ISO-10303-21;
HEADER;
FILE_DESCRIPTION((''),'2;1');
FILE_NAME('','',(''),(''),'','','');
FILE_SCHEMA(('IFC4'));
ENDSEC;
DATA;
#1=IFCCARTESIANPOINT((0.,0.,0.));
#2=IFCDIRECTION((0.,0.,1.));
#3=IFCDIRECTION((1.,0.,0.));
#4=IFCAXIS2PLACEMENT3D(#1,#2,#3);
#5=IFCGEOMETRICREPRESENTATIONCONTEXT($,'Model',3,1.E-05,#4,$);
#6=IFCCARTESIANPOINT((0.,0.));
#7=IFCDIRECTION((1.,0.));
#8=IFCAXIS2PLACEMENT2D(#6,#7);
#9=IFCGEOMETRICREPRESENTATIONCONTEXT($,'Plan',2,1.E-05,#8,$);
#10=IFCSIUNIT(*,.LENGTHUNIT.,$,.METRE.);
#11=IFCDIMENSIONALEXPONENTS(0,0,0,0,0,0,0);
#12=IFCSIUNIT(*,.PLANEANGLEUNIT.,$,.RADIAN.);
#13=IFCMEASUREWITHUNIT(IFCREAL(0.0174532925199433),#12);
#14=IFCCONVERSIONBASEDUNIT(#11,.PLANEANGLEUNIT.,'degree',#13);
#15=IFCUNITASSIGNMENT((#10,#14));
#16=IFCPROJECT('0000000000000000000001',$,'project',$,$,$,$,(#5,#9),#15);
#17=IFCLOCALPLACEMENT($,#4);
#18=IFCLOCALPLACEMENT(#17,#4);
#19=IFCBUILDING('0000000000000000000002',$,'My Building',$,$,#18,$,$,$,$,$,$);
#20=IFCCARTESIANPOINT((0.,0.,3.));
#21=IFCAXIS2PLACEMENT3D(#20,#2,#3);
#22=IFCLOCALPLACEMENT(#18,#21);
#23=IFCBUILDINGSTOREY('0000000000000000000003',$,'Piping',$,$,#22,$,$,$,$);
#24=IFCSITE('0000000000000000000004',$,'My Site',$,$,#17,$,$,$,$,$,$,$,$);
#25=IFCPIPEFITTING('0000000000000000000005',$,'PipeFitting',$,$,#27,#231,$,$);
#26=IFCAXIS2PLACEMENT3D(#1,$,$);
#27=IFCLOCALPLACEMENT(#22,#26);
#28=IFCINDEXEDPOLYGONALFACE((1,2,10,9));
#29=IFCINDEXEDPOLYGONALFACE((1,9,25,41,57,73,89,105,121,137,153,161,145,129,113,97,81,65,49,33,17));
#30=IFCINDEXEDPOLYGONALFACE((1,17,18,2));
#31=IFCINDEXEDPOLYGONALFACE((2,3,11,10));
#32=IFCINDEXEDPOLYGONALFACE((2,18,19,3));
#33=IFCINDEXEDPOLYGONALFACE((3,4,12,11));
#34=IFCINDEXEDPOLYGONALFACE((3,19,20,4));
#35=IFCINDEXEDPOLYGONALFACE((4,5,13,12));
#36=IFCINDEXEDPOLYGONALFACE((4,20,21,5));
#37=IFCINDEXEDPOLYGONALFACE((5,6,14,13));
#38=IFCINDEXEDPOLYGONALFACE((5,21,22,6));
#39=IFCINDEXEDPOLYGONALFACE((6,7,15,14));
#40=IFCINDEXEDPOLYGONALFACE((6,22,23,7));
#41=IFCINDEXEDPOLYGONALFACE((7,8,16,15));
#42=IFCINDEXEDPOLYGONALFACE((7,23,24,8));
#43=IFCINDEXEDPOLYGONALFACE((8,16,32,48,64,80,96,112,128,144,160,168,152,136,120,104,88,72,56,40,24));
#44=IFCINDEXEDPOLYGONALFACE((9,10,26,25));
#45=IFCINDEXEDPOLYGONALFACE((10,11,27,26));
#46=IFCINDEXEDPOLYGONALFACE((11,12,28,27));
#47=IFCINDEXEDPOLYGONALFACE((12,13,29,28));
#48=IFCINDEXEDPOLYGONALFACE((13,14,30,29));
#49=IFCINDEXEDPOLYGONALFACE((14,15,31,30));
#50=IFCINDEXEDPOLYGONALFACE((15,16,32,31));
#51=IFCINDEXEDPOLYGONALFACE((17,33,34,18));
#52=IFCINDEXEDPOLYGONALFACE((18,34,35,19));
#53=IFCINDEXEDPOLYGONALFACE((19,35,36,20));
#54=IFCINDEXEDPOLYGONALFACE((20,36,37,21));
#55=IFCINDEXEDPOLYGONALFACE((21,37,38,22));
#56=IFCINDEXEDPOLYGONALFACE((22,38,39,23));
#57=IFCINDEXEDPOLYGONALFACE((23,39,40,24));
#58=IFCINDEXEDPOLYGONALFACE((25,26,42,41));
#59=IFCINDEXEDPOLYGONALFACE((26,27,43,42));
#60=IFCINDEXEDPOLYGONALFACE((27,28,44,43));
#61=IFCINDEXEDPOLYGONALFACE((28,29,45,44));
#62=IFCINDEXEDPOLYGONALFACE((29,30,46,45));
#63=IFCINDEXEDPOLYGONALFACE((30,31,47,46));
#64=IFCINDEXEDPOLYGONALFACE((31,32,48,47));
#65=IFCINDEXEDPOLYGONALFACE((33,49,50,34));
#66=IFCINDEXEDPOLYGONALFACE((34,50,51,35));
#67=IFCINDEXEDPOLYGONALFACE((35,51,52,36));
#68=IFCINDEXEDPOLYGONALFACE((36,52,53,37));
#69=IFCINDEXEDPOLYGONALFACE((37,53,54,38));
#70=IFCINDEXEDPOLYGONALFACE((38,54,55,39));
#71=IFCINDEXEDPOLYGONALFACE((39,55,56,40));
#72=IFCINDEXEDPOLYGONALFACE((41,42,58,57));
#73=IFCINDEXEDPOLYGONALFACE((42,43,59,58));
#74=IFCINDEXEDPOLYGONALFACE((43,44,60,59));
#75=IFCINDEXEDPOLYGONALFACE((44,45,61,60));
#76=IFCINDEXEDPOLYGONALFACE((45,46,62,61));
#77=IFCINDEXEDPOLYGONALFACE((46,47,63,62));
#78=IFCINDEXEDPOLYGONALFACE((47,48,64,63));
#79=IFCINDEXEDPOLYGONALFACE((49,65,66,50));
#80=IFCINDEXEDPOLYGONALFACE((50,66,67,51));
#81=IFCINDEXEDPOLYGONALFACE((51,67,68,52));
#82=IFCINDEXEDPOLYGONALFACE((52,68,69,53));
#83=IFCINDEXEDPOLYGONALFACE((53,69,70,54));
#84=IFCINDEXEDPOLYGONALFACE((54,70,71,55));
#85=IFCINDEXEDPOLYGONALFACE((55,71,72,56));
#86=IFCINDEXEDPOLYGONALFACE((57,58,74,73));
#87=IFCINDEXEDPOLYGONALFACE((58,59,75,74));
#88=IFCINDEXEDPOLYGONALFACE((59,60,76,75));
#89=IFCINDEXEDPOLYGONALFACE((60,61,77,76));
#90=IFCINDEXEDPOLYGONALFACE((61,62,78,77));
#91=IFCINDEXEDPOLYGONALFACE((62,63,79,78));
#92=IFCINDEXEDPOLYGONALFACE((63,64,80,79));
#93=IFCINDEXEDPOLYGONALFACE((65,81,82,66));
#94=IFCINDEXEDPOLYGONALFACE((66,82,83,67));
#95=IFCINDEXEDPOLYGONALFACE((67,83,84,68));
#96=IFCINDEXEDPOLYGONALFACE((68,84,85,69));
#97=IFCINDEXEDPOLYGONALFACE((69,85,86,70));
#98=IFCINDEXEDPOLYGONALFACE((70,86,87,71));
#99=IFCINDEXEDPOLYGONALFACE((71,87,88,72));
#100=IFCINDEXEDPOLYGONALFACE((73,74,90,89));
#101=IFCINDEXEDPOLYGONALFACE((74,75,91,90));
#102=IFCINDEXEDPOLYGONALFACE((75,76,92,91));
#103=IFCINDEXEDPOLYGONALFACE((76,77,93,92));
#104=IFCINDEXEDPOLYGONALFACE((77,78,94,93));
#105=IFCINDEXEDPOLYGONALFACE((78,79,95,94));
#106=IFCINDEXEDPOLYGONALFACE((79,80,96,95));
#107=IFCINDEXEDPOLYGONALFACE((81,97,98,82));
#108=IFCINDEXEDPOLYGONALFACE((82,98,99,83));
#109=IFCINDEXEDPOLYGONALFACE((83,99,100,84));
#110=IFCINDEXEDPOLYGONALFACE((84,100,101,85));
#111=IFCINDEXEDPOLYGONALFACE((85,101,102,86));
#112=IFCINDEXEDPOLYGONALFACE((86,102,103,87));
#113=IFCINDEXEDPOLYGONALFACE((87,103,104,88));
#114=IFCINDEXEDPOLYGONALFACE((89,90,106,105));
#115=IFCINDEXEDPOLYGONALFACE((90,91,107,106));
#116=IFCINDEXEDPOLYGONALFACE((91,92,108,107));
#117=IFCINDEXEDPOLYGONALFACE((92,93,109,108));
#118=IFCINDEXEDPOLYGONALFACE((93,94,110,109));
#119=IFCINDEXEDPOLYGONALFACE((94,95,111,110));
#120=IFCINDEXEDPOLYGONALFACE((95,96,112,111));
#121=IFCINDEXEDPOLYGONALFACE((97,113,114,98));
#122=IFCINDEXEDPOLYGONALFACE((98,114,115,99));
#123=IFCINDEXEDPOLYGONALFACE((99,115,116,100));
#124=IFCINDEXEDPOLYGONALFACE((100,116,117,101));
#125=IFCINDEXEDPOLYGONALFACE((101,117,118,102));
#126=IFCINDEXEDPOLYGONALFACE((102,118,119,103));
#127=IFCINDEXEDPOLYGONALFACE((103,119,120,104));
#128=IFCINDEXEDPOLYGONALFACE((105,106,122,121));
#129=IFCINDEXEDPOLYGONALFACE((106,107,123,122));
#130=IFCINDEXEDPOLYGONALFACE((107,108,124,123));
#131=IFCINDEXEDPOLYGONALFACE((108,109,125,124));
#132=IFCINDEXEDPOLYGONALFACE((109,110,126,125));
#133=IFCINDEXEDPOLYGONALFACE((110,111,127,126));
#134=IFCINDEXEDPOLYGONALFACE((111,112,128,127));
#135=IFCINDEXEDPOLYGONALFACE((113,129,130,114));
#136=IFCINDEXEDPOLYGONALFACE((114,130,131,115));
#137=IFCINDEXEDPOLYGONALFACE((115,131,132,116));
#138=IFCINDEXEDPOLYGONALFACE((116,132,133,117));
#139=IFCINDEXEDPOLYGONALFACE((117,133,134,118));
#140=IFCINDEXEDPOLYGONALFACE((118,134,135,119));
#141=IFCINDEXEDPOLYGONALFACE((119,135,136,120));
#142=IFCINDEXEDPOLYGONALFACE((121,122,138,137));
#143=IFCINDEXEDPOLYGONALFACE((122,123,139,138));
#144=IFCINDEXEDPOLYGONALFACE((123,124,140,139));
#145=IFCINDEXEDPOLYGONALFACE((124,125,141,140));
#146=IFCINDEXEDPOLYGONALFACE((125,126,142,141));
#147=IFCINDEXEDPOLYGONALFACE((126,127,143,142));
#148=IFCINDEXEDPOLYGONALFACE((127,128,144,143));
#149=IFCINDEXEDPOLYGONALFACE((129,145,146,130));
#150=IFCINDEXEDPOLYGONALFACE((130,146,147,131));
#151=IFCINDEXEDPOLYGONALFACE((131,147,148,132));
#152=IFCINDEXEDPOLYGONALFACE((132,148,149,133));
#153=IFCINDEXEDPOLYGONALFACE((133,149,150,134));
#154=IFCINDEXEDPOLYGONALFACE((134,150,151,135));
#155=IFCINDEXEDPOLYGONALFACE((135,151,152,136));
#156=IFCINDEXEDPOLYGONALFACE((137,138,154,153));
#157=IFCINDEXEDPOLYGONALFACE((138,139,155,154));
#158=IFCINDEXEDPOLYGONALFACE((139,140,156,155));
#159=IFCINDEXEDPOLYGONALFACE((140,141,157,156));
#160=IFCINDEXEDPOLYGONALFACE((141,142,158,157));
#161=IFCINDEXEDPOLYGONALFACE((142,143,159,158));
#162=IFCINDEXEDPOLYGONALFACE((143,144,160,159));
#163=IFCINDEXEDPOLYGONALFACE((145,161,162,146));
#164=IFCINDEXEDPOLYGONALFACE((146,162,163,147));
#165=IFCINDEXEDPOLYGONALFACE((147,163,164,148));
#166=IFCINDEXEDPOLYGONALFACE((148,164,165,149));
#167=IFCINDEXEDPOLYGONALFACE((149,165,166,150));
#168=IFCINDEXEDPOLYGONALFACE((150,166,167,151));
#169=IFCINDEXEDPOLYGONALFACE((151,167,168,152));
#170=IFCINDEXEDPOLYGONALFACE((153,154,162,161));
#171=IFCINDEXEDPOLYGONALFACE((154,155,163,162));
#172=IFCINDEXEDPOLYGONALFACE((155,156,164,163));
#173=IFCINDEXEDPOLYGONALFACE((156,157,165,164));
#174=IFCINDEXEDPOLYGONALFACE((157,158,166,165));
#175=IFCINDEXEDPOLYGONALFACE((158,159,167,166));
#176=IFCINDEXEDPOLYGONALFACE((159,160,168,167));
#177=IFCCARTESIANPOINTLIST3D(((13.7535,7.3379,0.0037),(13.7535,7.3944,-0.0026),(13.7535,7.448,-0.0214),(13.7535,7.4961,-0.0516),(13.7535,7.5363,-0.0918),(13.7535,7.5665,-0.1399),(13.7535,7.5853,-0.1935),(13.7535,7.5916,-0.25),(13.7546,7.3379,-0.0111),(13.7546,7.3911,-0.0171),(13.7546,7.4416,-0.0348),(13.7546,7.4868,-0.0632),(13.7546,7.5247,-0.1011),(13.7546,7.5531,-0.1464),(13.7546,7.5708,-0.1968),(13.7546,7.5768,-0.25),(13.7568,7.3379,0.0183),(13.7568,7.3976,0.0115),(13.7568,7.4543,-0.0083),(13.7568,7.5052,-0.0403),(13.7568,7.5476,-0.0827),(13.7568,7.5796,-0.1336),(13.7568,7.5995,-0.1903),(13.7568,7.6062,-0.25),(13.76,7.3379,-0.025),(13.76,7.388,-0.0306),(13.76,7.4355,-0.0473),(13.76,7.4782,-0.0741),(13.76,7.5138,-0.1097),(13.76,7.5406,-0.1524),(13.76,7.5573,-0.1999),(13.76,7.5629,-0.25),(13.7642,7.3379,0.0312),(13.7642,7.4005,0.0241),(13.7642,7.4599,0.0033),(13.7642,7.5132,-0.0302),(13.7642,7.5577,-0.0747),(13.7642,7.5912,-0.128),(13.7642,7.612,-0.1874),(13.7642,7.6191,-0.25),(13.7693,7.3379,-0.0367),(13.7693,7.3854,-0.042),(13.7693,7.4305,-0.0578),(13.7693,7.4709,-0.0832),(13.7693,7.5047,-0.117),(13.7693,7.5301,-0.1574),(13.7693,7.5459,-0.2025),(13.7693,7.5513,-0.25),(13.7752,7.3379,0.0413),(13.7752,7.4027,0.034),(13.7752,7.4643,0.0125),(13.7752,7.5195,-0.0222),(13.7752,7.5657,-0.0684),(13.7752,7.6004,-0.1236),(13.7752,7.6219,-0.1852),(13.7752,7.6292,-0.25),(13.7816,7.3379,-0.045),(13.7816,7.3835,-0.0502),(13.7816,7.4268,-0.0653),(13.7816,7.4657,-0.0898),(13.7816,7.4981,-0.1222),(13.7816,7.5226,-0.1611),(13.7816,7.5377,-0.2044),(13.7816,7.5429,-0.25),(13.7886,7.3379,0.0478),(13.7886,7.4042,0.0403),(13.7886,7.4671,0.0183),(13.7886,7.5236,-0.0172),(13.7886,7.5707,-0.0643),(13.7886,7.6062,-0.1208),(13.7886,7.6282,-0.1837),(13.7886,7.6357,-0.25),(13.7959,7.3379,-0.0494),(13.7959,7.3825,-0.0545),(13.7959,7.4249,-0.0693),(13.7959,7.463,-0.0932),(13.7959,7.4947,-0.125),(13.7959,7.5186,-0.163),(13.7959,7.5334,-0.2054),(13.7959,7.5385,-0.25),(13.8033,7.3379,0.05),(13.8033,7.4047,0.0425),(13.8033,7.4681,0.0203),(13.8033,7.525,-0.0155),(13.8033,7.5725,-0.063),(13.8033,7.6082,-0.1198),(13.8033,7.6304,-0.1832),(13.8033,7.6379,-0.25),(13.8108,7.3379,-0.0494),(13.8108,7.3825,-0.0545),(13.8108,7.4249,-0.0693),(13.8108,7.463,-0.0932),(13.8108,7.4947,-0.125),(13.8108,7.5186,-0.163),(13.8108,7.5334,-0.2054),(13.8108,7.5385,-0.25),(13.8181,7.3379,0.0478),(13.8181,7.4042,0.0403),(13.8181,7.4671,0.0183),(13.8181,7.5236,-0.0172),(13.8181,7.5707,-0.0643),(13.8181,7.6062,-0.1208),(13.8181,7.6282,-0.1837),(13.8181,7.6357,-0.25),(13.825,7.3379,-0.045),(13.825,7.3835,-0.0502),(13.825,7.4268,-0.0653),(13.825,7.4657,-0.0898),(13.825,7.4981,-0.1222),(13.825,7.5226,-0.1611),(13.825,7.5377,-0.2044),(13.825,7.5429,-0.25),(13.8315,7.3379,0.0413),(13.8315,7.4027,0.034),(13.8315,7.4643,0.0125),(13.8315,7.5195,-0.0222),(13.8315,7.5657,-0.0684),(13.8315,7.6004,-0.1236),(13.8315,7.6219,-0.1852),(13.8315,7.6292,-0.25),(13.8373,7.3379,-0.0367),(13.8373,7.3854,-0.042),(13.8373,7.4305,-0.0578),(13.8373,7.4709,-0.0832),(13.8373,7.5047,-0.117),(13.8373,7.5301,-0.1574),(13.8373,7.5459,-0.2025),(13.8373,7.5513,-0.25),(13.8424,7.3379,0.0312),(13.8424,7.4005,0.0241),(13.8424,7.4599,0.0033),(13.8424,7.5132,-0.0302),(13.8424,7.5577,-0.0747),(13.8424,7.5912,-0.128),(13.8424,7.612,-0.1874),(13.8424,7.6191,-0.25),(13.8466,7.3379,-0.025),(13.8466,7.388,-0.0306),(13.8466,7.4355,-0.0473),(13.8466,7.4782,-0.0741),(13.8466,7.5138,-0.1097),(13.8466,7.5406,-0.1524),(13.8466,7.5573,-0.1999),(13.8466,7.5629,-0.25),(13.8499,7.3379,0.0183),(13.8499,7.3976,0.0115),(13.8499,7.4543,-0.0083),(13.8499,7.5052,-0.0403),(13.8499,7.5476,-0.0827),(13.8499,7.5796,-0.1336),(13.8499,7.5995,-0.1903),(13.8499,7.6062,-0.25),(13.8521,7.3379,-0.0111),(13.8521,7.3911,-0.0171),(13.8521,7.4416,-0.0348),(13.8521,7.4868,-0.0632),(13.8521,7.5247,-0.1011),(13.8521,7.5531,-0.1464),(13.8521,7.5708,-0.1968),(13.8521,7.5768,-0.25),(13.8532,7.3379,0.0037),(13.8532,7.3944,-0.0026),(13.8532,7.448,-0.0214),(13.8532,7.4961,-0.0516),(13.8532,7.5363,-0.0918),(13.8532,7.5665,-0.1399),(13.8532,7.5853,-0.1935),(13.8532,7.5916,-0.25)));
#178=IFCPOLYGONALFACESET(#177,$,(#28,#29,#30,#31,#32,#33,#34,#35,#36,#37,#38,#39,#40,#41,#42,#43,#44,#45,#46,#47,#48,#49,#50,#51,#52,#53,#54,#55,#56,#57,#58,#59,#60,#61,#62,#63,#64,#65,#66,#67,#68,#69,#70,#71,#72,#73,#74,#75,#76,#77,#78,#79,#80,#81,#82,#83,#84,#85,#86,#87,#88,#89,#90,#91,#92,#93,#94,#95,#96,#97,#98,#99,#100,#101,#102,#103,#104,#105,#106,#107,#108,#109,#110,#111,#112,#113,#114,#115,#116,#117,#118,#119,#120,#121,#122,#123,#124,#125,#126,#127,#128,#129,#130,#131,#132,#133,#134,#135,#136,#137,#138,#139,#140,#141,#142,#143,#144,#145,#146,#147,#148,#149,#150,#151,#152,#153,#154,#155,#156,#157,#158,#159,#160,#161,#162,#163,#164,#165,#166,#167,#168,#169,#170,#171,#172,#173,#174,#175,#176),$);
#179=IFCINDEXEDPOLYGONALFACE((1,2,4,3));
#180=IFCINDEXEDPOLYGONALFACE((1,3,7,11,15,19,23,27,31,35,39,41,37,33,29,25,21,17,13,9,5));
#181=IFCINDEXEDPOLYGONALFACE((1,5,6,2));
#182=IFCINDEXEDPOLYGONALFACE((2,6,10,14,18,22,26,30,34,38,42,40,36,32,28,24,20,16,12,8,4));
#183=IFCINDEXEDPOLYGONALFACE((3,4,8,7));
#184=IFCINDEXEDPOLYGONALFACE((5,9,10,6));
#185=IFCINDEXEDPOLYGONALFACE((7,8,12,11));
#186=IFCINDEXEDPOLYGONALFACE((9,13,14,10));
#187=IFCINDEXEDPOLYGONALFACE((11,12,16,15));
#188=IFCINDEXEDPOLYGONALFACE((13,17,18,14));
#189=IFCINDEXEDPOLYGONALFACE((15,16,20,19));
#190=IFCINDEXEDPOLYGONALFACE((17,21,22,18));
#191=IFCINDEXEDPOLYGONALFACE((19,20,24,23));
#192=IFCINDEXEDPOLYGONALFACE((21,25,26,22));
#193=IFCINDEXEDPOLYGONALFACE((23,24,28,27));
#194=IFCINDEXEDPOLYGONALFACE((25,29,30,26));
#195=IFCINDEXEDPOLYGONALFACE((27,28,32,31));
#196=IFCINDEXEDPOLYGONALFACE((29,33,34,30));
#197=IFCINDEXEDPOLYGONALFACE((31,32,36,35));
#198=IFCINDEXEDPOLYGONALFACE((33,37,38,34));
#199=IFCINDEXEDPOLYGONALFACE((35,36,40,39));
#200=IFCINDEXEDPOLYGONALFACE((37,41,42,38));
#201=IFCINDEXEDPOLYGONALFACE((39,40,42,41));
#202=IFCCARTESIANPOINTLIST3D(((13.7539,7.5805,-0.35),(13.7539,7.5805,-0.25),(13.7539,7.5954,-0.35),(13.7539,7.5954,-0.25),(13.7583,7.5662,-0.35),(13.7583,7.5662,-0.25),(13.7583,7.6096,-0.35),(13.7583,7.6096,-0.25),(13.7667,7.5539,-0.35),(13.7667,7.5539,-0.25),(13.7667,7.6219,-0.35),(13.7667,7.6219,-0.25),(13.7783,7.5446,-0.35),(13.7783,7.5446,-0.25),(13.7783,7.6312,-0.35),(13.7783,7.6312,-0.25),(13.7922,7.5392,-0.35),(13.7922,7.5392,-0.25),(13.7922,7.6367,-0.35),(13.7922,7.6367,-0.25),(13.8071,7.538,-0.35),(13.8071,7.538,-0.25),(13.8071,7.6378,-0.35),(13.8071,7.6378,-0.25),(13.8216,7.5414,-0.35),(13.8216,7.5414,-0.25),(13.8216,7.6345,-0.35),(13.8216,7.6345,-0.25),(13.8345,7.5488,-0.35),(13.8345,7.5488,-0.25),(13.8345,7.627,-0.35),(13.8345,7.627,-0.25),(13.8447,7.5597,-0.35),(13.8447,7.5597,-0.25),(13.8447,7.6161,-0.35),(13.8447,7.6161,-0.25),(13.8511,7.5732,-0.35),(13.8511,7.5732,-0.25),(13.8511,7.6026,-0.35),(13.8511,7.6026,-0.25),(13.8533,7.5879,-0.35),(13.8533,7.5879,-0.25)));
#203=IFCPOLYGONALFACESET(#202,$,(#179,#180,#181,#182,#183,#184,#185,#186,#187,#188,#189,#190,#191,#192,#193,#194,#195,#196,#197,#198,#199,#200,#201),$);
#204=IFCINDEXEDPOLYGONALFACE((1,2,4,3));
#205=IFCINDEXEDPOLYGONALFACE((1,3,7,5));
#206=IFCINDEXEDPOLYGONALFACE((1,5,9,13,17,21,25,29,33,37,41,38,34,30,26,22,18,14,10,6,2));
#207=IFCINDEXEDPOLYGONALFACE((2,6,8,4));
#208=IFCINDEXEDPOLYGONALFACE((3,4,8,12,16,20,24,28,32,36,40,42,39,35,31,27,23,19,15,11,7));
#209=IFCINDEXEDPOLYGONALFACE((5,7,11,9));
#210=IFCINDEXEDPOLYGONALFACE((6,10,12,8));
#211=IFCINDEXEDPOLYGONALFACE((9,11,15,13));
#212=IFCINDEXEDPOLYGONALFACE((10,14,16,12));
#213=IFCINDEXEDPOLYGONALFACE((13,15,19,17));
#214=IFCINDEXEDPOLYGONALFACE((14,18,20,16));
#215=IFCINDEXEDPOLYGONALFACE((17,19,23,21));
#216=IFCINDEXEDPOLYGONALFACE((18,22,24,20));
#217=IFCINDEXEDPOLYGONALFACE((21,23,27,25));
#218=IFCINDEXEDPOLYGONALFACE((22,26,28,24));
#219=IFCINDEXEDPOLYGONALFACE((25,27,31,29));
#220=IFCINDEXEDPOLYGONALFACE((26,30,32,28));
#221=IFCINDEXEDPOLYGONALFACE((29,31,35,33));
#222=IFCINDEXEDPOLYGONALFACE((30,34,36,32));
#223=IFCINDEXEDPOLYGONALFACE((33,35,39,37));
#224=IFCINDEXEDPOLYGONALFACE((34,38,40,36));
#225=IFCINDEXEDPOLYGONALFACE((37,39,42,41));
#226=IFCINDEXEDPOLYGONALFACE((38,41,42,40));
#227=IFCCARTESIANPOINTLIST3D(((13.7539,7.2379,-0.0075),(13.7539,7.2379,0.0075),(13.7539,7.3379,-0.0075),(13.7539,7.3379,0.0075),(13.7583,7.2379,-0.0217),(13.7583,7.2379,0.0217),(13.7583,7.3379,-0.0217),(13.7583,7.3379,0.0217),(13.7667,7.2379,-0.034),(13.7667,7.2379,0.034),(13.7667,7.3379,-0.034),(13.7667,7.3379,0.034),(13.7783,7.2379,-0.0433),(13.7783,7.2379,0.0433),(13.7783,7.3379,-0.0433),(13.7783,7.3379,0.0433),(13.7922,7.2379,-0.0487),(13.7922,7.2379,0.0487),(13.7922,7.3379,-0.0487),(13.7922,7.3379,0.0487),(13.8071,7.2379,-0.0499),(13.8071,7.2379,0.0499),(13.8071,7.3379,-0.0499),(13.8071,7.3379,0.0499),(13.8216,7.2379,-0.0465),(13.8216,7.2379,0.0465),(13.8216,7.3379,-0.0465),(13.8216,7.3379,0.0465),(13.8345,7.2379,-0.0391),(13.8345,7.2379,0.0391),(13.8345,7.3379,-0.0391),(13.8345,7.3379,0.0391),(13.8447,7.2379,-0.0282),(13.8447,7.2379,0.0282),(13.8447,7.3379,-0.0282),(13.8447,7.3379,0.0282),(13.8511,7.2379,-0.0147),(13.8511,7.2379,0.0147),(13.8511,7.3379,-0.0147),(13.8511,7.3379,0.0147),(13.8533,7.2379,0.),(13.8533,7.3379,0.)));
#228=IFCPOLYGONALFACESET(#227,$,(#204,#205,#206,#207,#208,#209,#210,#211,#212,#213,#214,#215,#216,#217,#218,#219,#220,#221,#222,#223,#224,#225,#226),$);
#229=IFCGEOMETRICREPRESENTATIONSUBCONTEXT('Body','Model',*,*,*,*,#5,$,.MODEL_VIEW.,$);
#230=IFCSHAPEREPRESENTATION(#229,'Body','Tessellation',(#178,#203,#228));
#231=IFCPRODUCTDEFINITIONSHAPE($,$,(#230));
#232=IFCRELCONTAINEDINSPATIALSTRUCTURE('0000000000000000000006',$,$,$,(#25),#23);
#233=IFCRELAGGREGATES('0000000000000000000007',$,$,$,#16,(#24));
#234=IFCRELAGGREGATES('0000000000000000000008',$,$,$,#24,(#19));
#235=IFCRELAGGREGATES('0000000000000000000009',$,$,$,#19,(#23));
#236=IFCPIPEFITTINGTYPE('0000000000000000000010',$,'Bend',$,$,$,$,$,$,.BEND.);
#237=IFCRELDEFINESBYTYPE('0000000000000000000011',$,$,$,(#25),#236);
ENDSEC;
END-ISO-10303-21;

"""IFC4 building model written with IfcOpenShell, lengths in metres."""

from ifc_helpers import new_model, entity, si_unit, converted_unit, frame, origin_with_axes, origin_2d_with_axis, place, context, subcontext, project, spatial, line, indexed_curve, circle, outline, extrude, source, transform, mapped, type_object, type_shapes, element, save


model = new_model("IFC4")

# Units and contexts
model_context = context("Model", 3, precision=1e-05, world=origin_with_axes())
plan_context = context("Plan", 2, precision=1e-05, world=origin_2d_with_axis())
body_context = subcontext(model_context, "Body", "Model", "MODEL_VIEW")
ifc_project = project(units=[si_unit("LENGTHUNIT", "METRE"), converted_unit("PLANEANGLEUNIT", "degree", entity("IfcReal", 0.0174532925199433), si_unit("PLANEANGLEUNIT", "RADIAN"), dimensions=[0, 0, 0, 0, 0, 0, 0])], contexts=[model_context, plan_context])

# Site, building, storey
site_placement = place(None, origin_with_axes())
site = spatial("IfcSite", under=ifc_project, at=site_placement, Name="My Site")
building_placement = place(site_placement, origin_with_axes())
building = spatial("IfcBuilding", under=site, at=building_placement, Name="My Building")
storey_placement = place(building_placement, frame((0.0, 0.0, 3.0), z_axis=(0.0, 0.0, 1.0), x_axis=(1.0, 0.0, 0.0)))
storey = spatial("IfcBuildingStorey", under=building, at=storey_placement, Name="Piping")

# Pipe fitting, opening
pipe_fitting_type = type_object("IfcPipeFittingType", Name="Bend", PredefinedType="BEND")
shared_shape = source(origin_with_axes(), body_context, "Body", "SolidModel", [
    entity("IfcSweptDiskSolid", entity("IfcIndexedPolyCurve", entity("IfcCartesianPointList3D", [[0.0, 0.0, -0.1], [0.0, 0.0732, -0.2768], [0.0, 0.25, -0.35]]), [entity("IfcArcIndex", [1, 2, 3])]), 0.05),
    extrude(circle(Radius=0.05), origin_with_axes(), (0.0, 0.0, -1.0), 0.1),
    extrude(circle(Radius=0.05), frame((0.0, 0.25, -0.35), z_axis=(0.0, 1.0, 0.0), x_axis=(1.0, 0.0, 0.0)), (0.0, 0.0, 1.0), 0.1),
])
type_shapes(pipe_fitting_type, [shared_shape])
pipe_fitting_1_placement = place(storey_placement, frame((13.8033, 7.5879, -0.35), z_axis=(0.0, 0.0, -1.0), x_axis=(1.0, 0.0, 0.0)))
pipe_fitting_1 = element("IfcPipeFitting", 1, at=pipe_fitting_1_placement, inside=storey, type_object=pipe_fitting_type, Name="PipeFitting", context=body_context, shape_type="MappedRepresentation", body=[
    mapped(shared_shape, transform((0.0, 0.0, 0.0), x_axis=(1.0, 0.0, 0.0), y_axis=(0.0, 1.0, 0.0), z_axis=(0.0, 0.0, 1.0), scale=1.0)),
])
opening_1_placement = place(pipe_fitting_1_placement, frame((1.9673, -1.5235, 2.65), z_axis=(0.0, 0.0, -1.0), x_axis=(-1.0, 0.0, 0.0)))
element("IfcOpeningElement", 2, at=opening_1_placement, cuts=pipe_fitting_1, PredefinedType="OPENING", context=body_context, shape_type="SweptSolid", body=[
    extrude(outline(indexed_curve([(0.0, 0.0), (0.5, 0.0), (0.5, 0.5), (0.0, 0.5)], segments=[line(1, 2, 3, 4, 1)])), origin_with_axes(), (0.0, 0.0, 1.0), 0.5),
])

save(model, "model.ifc")
